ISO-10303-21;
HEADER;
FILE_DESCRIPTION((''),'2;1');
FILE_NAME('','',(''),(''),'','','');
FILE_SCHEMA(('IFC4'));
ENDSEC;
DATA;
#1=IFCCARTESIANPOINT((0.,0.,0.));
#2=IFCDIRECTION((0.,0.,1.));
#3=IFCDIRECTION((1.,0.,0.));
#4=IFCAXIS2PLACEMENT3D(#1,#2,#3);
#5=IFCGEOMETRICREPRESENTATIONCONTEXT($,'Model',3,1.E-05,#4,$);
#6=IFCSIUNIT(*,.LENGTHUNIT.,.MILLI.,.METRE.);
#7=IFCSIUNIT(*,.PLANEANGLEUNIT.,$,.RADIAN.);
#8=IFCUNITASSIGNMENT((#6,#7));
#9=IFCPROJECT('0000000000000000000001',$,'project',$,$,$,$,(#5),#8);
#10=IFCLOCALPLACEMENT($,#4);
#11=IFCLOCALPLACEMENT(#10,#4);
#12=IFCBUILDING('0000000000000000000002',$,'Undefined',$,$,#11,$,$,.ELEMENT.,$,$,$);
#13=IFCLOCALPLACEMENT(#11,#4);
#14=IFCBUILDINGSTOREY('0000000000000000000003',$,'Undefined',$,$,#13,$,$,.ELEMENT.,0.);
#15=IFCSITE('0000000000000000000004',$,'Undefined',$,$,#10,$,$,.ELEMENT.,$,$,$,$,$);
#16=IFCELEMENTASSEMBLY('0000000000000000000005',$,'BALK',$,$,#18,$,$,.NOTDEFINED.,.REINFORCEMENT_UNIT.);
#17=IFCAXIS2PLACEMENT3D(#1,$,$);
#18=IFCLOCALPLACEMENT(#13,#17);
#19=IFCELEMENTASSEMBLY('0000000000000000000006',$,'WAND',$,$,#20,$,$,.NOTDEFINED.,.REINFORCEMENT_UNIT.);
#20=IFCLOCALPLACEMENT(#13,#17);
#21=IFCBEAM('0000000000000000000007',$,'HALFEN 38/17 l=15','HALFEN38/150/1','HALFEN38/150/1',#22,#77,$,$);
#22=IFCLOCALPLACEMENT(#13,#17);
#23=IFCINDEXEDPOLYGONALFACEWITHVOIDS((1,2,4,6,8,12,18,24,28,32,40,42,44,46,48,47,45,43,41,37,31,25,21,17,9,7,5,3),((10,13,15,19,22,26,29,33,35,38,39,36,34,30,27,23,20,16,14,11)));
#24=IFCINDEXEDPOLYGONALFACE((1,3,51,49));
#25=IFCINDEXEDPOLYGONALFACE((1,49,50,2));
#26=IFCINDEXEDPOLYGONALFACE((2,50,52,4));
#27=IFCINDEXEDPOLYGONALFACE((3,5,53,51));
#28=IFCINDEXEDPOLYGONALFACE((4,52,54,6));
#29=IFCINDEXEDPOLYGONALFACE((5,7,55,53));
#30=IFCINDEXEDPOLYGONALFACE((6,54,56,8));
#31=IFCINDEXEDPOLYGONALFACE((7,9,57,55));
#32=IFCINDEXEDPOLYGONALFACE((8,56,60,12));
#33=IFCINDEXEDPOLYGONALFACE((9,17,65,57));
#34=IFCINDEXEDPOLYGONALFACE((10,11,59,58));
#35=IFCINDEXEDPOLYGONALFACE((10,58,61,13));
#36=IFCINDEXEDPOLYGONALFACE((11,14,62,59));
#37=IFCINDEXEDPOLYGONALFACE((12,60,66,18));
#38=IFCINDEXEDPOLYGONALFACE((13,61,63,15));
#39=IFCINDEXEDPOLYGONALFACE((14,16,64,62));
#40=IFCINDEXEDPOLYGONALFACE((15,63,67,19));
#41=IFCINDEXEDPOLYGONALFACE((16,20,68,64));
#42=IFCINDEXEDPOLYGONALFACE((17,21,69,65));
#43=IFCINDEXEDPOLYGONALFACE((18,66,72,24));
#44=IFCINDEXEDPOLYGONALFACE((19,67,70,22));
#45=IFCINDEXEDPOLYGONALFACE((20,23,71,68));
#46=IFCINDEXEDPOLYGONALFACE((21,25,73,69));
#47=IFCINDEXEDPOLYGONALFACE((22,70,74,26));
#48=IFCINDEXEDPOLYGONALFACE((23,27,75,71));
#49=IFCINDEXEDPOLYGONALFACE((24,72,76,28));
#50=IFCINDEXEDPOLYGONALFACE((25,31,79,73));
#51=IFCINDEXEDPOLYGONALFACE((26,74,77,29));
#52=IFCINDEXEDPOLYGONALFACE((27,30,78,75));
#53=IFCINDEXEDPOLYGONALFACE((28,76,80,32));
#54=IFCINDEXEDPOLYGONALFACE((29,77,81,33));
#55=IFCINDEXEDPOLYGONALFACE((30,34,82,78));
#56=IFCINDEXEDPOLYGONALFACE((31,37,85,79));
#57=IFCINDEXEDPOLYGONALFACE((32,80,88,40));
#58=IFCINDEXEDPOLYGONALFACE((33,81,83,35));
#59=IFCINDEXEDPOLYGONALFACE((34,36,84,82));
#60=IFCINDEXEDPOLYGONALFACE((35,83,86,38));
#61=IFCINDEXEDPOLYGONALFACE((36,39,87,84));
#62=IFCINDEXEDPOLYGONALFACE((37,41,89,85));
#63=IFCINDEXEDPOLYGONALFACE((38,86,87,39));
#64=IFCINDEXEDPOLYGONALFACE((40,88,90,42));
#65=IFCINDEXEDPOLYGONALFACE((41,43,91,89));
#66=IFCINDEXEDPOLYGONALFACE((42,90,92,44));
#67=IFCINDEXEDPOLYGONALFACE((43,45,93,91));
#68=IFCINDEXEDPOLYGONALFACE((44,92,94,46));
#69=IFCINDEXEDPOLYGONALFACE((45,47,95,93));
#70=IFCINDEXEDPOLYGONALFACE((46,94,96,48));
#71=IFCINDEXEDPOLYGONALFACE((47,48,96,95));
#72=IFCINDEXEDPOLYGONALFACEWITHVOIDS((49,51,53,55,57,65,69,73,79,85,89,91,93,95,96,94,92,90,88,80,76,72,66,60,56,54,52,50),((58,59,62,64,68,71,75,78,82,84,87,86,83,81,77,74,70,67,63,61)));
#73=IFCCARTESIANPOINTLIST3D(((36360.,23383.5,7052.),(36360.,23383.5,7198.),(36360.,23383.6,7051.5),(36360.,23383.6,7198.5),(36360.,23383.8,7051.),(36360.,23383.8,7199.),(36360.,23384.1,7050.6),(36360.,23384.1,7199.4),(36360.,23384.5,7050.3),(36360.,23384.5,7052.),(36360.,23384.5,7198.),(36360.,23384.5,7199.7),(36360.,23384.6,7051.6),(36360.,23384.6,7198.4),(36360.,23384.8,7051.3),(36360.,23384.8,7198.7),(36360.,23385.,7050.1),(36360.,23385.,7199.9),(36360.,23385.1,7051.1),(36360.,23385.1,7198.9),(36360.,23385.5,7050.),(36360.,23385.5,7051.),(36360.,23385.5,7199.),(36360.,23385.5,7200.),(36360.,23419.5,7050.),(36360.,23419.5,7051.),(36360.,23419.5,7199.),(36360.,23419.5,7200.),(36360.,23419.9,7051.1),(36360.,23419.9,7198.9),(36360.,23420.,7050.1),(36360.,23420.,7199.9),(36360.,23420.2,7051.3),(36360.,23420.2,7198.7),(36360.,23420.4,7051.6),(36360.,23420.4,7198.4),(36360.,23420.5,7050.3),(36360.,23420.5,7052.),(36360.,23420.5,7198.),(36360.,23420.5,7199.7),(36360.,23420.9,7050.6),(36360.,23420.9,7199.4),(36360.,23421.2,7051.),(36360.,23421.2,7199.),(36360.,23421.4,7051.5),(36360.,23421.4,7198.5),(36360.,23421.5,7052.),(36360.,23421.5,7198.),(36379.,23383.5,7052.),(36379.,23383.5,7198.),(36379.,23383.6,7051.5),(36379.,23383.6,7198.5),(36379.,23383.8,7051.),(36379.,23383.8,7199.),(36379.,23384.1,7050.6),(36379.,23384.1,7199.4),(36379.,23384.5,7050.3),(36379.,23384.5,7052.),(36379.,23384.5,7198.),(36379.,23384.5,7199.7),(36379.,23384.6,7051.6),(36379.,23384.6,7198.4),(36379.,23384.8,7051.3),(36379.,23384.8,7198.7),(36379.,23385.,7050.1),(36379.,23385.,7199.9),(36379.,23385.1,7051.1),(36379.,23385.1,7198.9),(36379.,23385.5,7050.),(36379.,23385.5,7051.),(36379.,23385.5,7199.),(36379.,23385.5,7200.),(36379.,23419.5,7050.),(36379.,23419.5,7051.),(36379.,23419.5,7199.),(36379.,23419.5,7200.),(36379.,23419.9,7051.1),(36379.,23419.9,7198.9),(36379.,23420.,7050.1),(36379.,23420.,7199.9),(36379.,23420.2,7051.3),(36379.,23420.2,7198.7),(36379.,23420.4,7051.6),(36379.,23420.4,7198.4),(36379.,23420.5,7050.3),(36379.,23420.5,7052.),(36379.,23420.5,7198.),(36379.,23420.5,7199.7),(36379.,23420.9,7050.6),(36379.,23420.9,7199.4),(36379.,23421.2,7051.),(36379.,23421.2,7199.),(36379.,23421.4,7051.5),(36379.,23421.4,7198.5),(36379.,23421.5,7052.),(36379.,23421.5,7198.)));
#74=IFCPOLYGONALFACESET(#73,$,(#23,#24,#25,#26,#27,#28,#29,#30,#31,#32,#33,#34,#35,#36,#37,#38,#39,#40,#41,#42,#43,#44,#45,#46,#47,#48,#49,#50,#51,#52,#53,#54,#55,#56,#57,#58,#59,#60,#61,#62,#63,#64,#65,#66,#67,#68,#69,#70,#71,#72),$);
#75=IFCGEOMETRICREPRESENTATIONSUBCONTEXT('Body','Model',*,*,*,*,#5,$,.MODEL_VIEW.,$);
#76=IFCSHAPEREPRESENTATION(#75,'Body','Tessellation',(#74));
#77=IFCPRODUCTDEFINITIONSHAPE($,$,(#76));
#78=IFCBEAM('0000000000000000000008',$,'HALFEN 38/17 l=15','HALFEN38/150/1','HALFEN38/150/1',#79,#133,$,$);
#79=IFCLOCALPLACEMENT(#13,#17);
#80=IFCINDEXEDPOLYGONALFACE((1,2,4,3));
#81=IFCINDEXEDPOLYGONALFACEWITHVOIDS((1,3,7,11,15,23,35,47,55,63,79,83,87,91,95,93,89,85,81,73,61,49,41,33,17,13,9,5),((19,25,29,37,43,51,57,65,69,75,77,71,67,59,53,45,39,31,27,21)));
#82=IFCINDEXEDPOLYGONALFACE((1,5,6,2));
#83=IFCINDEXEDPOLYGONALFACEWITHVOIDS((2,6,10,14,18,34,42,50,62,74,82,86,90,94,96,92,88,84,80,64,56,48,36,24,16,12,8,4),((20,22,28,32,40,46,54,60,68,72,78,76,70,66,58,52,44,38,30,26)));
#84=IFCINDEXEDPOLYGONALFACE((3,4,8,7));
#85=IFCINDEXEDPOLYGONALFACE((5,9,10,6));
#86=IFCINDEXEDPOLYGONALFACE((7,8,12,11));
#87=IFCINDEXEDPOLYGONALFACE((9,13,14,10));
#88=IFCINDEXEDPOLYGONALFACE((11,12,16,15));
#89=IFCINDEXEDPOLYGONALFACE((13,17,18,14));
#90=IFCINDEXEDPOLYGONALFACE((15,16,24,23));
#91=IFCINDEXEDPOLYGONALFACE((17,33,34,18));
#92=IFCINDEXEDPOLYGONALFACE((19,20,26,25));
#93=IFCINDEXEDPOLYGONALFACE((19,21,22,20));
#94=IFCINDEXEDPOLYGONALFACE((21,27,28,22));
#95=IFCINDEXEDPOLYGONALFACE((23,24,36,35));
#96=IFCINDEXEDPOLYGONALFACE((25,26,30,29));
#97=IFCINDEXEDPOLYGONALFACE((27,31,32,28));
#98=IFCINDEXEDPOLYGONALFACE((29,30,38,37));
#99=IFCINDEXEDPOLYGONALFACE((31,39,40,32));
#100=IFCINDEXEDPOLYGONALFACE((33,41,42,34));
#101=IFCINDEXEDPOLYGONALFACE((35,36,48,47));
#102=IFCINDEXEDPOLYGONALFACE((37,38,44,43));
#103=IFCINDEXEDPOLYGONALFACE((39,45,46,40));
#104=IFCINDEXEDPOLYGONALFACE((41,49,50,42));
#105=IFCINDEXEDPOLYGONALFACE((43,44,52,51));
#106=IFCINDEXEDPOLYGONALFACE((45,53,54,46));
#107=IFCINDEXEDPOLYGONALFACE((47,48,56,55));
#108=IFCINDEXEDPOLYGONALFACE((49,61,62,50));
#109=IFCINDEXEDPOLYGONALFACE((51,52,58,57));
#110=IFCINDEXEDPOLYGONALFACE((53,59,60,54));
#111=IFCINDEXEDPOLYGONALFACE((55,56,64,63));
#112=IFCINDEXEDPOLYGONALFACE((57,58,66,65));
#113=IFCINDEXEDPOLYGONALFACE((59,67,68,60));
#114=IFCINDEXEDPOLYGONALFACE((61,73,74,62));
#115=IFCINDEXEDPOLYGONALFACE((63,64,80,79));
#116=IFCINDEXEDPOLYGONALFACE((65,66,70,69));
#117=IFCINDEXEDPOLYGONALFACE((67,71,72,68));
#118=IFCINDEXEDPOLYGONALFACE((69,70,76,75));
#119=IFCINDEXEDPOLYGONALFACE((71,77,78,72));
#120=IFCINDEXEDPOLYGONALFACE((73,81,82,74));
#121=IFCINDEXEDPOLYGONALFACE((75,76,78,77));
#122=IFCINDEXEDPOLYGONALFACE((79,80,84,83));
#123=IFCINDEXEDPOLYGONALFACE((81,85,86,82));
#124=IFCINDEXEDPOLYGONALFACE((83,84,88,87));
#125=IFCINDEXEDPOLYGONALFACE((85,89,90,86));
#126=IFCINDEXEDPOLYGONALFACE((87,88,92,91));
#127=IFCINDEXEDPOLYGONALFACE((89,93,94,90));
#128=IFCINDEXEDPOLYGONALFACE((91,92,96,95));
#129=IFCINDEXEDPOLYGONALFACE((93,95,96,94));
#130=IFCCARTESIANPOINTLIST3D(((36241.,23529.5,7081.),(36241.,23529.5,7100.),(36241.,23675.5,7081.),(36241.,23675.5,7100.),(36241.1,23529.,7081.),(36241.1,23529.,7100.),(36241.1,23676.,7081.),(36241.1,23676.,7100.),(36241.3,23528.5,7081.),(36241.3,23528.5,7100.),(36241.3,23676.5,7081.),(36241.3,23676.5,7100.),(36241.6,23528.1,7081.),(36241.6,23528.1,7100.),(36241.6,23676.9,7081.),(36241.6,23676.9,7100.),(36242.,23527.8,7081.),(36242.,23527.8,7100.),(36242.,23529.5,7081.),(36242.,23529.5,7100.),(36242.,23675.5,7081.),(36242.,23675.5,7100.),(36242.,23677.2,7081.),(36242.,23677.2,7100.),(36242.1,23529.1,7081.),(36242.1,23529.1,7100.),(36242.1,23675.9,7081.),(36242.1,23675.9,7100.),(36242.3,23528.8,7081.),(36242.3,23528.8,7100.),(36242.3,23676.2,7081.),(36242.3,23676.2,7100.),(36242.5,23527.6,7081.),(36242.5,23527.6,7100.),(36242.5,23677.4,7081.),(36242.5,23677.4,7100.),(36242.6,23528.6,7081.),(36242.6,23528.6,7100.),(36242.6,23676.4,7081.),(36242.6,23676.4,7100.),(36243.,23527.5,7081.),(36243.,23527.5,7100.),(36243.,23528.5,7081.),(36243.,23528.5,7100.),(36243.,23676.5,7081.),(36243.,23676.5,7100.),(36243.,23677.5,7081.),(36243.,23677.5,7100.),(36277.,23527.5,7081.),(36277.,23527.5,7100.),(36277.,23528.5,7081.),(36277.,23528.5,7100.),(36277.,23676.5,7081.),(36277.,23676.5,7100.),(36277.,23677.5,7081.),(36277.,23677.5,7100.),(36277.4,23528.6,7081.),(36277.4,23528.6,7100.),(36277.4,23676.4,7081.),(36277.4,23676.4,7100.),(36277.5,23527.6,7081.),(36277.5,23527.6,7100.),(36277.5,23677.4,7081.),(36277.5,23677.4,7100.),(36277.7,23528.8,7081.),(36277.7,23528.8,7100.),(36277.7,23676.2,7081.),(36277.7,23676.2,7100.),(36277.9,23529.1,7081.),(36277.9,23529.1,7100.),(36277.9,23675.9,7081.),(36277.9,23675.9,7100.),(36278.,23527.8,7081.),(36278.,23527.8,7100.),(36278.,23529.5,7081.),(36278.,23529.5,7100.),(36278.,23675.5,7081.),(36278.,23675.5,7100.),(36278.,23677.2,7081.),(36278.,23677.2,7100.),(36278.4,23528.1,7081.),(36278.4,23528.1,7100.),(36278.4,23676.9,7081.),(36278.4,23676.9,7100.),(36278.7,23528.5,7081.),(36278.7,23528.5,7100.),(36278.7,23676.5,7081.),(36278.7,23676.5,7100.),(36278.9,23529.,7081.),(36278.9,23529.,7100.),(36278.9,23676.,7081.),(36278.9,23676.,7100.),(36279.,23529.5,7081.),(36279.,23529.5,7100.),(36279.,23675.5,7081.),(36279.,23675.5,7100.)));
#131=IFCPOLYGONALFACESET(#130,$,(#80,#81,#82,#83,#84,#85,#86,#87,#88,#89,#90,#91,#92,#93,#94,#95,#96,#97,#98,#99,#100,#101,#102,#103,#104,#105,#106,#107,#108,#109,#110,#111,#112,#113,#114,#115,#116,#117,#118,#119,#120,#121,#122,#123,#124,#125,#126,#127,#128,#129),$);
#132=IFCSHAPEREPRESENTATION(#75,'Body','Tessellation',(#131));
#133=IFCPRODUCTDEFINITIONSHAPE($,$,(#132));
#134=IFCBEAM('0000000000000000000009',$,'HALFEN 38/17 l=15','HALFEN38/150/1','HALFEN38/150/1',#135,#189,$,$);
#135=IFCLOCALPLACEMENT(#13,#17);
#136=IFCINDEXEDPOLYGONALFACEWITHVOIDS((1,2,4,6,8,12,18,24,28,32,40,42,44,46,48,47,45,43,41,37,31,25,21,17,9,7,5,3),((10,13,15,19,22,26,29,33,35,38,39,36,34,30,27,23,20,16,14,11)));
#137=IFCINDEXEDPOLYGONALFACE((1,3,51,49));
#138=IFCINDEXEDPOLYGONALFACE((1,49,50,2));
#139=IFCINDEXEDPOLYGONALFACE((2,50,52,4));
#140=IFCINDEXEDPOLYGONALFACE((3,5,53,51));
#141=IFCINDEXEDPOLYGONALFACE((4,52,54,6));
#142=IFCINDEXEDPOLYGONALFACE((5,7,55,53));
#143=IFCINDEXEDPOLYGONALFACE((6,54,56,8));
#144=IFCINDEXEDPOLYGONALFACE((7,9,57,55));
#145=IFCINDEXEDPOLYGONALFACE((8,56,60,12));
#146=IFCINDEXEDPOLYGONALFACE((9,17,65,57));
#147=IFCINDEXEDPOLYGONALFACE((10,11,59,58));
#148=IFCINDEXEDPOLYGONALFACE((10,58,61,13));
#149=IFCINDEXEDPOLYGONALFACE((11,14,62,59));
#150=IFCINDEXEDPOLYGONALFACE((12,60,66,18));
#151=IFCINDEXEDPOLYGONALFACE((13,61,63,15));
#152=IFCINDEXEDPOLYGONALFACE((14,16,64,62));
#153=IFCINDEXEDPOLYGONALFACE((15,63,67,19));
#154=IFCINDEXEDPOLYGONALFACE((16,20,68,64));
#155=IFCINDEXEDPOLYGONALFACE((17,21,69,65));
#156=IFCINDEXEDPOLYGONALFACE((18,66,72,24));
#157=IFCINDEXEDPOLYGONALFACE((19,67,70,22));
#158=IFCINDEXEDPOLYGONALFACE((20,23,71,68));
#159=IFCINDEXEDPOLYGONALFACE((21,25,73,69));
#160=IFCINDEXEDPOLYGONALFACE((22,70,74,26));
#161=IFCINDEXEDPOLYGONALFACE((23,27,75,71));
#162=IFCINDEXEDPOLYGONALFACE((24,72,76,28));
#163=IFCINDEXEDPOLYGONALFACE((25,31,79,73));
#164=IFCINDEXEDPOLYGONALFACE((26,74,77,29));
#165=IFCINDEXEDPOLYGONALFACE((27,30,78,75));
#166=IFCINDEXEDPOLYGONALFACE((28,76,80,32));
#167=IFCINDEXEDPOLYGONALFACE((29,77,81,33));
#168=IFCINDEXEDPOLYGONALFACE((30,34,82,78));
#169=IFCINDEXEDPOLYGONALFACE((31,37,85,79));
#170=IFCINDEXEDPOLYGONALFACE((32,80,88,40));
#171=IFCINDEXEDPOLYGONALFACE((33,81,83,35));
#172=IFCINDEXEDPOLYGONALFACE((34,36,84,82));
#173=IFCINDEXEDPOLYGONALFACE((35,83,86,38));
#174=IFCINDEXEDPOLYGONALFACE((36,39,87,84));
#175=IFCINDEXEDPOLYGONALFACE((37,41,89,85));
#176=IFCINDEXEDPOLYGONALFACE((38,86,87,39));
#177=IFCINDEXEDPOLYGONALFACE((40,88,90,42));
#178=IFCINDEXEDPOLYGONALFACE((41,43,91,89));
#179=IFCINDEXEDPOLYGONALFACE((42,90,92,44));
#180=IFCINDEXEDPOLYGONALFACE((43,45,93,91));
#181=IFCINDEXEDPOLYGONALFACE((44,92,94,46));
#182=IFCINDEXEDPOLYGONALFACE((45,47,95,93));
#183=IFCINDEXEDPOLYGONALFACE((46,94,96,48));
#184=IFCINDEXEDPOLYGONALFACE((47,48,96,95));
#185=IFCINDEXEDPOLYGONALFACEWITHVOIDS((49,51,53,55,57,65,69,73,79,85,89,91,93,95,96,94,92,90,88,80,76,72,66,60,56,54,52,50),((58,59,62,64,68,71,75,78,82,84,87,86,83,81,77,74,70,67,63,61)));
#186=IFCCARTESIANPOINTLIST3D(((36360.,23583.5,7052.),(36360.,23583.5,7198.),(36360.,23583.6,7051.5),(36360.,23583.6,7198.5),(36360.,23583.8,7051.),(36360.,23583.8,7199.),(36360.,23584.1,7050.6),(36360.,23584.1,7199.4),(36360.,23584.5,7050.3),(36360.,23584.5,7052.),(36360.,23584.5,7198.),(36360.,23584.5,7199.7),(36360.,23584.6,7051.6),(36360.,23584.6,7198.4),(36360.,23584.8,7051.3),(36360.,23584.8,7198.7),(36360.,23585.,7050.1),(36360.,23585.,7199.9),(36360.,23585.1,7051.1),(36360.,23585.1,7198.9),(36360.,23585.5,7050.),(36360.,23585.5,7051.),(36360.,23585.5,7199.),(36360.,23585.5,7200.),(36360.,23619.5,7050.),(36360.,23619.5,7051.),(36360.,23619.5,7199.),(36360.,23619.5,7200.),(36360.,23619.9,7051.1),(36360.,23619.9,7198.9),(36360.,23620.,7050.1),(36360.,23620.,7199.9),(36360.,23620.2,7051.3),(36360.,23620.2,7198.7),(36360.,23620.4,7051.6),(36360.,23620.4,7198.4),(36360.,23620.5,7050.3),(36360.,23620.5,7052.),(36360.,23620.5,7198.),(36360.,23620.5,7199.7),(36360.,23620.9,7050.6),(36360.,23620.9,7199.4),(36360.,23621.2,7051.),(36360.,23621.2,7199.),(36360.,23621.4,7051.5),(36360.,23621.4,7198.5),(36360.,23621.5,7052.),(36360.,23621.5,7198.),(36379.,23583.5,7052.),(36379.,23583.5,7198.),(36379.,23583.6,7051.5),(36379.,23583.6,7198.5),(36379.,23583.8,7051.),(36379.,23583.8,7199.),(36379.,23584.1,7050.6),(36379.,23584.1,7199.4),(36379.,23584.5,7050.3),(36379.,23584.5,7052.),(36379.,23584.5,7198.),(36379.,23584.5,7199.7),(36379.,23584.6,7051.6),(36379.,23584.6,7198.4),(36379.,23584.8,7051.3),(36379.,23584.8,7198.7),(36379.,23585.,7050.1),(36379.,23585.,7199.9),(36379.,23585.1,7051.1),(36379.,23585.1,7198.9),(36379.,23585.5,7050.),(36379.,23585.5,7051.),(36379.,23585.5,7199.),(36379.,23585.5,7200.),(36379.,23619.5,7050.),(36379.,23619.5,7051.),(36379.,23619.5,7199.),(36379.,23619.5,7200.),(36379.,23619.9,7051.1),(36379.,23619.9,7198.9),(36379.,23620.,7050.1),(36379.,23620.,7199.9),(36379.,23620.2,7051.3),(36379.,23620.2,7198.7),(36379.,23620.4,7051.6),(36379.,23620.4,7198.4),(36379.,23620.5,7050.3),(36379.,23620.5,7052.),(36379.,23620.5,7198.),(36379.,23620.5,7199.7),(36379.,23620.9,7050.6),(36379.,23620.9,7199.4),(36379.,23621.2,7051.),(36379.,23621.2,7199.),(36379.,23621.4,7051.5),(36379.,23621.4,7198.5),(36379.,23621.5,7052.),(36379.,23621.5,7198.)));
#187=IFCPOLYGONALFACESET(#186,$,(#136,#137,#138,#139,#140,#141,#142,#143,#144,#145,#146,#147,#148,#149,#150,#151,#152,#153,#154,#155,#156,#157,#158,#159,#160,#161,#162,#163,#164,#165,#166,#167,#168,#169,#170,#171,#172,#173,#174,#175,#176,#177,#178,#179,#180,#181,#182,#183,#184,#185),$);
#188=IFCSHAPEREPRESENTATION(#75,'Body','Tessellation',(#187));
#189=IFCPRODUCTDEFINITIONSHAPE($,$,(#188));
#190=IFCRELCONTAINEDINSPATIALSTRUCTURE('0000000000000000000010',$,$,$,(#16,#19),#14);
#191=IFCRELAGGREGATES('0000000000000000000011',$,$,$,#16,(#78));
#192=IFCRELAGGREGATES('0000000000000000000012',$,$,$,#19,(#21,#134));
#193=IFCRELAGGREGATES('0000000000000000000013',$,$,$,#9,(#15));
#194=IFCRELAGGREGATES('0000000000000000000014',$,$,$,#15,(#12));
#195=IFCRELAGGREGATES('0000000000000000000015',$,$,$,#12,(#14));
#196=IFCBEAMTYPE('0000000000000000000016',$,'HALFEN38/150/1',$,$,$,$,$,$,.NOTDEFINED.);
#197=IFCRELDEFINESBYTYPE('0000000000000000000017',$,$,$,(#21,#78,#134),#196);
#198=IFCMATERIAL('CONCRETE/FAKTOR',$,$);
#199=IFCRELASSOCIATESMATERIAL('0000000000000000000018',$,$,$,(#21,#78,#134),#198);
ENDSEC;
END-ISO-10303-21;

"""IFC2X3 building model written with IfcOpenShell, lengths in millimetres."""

from ifc_helpers import new_model, si_unit, frame, frame_2d, origin_with_axes, place, context, subcontext, project, spatial, hollow_rectangle, extrude, material, type_object, element, aggregate, save


model = new_model("IFC2X3")

# Units and contexts
model_context = context("Model", 3, precision=1e-05, world=origin_with_axes())
body_context = subcontext(model_context, "Body", "Model", "MODEL_VIEW")
ifc_project = project(units=[si_unit("LENGTHUNIT", "METRE", prefix="MILLI"), si_unit("PLANEANGLEUNIT", "RADIAN")], contexts=[model_context])

# Site, building, storey
site_placement = place(None, origin_with_axes())
site = spatial("IfcSite", under=ifc_project, at=site_placement, Name="Undefined", CompositionType="ELEMENT")
building_placement = place(site_placement, origin_with_axes())
building = spatial("IfcBuilding", under=site, at=building_placement, Name="Undefined", CompositionType="ELEMENT")
storey_placement = place(building_placement, origin_with_axes())
storey = spatial("IfcBuildingStorey", under=building, at=storey_placement, Name="Undefined", CompositionType="ELEMENT", Elevation=0.0)

# Element assembly
assembly_1_placement = place(storey_placement, origin_with_axes())
assembly_1 = element("IfcElementAssembly", 1, at=assembly_1_placement, inside=storey, Name="BALK", AssemblyPlace="NOTDEFINED", PredefinedType="REINFORCEMENT_UNIT")
ifc_material_1 = material(Name="CONCRETE/FAKTOR")

# Element assembly
assembly_2_placement = place(storey_placement, origin_with_axes())
assembly_2 = element("IfcElementAssembly", 2, at=assembly_2_placement, inside=storey, Name="WAND", AssemblyPlace="NOTDEFINED", PredefinedType="REINFORCEMENT_UNIT")

# Beams
beam_type_1 = type_object("IfcBeamType", Name="HALFEN38/150/1", PredefinedType="NOTDEFINED")
beam_1_placement = place(assembly_2_placement, frame((36360.0, 23402.5, 7125.0), z_axis=(0.0, -1.0, 0.0), x_axis=(1.0, 0.0, 0.0)))
beam_1 = element("IfcBeam", 3, at=beam_1_placement, type_object=beam_type_1, material=ifc_material_1, Name="HALFEN 38/17 l=15", Description="HALFEN38/150/1", ObjectType="HALFEN38/150/1", context=body_context, shape_type="SweptSolid", body=[
    extrude(hollow_rectangle(XDim=150.0, YDim=38.0, WallThickness=1.0, InnerFilletRadius=1.0, OuterFilletRadius=2.0, at=frame_2d((0.0, 0.0), x_axis=(1.0, 0.0))), frame((19.0, 0.0, 0.0), z_axis=(-1.0, 0.0, 0.0), x_axis=(0.0, -1.0, 0.0)), (0.0, 0.0, 1.0), 19.0),
])
beam_2_placement = place(assembly_1_placement, frame((36260.0, 23602.5, 7100.0), z_axis=(1.0, 0.0, 0.0), x_axis=(0.0, 0.0, -1.0)))
beam_2 = element("IfcBeam", 4, at=beam_2_placement, type_object=beam_type_1, material=ifc_material_1, Name="HALFEN 38/17 l=15", Description="HALFEN38/150/1", ObjectType="HALFEN38/150/1", context=body_context, shape_type="SweptSolid", body=[
    extrude(hollow_rectangle(XDim=150.0, YDim=38.0, WallThickness=1.0, InnerFilletRadius=1.0, OuterFilletRadius=2.0, at=frame_2d((0.0, 0.0), x_axis=(1.0, 0.0))), frame((19.0, 0.0, 0.0), z_axis=(-1.0, 0.0, 0.0), x_axis=(0.0, -1.0, 0.0)), (0.0, 0.0, 1.0), 19.0),
])
aggregate(assembly_1, [beam_2])
beam_3_placement = place(assembly_2_placement, frame((36360.0, 23602.5, 7125.0), z_axis=(0.0, -1.0, 0.0), x_axis=(1.0, 0.0, 0.0)))
beam_3 = element("IfcBeam", 5, at=beam_3_placement, type_object=beam_type_1, material=ifc_material_1, Name="HALFEN 38/17 l=15", Description="HALFEN38/150/1", ObjectType="HALFEN38/150/1", context=body_context, shape_type="SweptSolid", body=[
    extrude(hollow_rectangle(XDim=150.0, YDim=38.0, WallThickness=1.0, InnerFilletRadius=1.0, OuterFilletRadius=2.0, at=frame_2d((0.0, 0.0), x_axis=(1.0, 0.0))), frame((19.0, 0.0, 0.0), z_axis=(-1.0, 0.0, 0.0), x_axis=(0.0, -1.0, 0.0)), (0.0, 0.0, 1.0), 19.0),
])
aggregate(assembly_2, [beam_1, beam_3])

save(model, "model.ifc")
